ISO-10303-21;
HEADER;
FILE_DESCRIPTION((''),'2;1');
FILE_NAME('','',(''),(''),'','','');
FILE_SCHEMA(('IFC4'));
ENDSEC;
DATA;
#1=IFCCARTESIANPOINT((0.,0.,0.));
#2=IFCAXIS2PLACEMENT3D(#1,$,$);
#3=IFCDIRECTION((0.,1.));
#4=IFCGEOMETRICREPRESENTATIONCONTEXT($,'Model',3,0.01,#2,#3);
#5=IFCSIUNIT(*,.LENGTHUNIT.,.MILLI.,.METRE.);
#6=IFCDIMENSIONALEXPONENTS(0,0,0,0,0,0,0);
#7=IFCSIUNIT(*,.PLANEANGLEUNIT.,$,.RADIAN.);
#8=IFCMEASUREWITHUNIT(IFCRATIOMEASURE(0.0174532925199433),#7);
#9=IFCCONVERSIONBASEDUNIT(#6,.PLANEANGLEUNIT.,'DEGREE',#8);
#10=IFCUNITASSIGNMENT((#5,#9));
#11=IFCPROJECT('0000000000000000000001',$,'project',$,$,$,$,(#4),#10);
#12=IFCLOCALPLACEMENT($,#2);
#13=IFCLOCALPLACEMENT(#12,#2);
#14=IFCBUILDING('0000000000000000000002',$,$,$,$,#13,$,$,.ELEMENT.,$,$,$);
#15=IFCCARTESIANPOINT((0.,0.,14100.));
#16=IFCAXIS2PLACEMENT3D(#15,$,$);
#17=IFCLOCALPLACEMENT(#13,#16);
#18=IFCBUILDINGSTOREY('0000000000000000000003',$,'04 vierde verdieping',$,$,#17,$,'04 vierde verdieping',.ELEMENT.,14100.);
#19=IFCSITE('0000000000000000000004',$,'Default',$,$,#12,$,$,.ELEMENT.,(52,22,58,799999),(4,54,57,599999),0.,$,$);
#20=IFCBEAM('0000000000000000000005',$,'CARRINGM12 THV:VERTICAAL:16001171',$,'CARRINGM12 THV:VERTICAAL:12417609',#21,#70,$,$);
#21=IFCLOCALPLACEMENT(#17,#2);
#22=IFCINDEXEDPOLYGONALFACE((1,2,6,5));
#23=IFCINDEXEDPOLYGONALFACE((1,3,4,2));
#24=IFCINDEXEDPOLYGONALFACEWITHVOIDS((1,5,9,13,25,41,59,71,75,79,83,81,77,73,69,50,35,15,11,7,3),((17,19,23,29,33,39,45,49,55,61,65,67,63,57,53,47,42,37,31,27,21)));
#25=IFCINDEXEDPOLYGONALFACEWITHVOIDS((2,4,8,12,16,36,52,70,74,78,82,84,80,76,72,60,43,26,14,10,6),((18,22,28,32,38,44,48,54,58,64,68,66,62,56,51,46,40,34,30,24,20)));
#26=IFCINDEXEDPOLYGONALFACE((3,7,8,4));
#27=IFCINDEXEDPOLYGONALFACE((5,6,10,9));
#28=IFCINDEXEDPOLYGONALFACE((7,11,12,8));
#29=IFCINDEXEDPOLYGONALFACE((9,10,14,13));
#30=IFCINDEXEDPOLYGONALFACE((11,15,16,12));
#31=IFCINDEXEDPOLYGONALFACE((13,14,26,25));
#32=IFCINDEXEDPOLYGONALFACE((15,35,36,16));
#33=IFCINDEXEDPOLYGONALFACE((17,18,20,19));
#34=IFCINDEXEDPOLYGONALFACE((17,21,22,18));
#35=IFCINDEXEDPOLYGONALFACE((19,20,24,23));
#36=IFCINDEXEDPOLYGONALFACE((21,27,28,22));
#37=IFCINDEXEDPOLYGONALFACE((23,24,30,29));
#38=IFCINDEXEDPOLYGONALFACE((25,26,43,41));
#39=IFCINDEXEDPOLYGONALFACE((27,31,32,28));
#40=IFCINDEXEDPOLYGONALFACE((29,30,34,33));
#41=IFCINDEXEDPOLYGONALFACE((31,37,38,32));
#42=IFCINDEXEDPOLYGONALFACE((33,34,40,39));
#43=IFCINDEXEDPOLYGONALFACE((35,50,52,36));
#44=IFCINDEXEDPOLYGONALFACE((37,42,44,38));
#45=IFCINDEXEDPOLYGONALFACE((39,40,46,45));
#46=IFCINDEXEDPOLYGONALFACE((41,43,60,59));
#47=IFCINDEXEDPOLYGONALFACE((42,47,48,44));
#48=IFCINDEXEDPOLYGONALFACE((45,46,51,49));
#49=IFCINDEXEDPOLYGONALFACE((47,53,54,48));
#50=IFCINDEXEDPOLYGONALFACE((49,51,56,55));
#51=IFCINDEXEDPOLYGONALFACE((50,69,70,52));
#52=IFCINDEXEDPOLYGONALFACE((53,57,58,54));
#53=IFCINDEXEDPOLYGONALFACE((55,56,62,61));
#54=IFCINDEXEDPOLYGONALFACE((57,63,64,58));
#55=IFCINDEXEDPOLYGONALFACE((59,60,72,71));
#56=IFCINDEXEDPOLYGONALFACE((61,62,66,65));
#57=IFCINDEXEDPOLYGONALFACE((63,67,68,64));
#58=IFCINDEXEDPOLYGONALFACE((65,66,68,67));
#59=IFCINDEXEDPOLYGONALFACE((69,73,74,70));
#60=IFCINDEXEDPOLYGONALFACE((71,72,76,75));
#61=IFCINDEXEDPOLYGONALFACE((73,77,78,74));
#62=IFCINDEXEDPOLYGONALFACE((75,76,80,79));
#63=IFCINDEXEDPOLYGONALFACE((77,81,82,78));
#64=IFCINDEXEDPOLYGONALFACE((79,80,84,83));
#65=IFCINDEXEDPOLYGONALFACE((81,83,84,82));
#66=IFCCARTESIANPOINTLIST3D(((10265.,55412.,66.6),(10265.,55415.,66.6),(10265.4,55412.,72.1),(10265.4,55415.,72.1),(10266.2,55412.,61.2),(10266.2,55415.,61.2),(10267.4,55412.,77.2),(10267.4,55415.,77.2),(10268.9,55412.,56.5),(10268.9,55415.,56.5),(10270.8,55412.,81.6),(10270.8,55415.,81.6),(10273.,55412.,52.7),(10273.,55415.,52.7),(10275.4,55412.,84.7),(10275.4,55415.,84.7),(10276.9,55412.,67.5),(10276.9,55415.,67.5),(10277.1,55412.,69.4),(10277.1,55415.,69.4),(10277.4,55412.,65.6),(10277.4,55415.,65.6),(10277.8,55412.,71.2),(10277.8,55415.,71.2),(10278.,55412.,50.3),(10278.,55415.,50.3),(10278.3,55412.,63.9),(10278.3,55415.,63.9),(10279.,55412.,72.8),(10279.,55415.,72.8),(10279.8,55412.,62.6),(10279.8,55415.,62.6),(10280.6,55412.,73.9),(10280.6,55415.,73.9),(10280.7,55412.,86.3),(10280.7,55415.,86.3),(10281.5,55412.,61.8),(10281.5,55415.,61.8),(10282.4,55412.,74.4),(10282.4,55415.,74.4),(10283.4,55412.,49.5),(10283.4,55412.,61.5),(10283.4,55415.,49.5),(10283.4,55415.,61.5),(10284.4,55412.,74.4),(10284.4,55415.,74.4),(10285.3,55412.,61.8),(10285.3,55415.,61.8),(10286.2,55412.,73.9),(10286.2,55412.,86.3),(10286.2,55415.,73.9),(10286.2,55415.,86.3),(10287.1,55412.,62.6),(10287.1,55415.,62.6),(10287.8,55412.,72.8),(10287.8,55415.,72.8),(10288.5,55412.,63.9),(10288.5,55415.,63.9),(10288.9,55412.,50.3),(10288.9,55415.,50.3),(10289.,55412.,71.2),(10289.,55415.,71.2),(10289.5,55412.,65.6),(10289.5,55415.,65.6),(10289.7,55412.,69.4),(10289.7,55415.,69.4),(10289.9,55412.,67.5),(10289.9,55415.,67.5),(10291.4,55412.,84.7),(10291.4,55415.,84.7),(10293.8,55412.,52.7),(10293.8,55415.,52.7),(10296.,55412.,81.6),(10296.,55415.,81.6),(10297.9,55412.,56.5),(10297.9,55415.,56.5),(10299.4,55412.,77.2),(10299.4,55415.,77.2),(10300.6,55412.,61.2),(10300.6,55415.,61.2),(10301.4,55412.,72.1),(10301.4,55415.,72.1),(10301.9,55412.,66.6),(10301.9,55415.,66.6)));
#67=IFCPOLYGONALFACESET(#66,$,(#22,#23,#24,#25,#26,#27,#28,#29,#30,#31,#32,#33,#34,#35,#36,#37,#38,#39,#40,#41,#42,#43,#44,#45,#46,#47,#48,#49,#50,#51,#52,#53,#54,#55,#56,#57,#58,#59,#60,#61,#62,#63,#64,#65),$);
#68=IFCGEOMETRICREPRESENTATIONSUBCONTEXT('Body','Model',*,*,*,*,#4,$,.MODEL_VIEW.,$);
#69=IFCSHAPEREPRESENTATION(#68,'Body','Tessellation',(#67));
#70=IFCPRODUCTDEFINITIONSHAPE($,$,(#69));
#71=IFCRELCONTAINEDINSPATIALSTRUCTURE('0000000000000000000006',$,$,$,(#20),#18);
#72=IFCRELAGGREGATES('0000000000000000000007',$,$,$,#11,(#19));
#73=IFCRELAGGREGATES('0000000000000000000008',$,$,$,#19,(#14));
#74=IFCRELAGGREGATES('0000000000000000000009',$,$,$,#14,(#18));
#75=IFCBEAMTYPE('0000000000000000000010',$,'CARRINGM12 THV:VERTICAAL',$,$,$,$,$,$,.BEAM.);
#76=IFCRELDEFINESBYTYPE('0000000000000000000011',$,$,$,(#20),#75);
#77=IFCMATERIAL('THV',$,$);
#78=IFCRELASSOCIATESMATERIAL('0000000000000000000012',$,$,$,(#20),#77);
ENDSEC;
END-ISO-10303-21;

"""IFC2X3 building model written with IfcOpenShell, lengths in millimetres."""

from ifc_helpers import new_model, entity, si_unit, converted_unit, direction, frame, origin, origin_2d_with_axis, place, context, subcontext, project, spatial, hollow_circle, extrude, material, type_object, element, save


model = new_model("IFC2X3")

# Units and contexts
model_context = context("Model", 3, precision=0.01, world=origin(), true_north=direction((0.0, 1.0)))
body_context = subcontext(model_context, "Body", "Model", "MODEL_VIEW")
ifc_project = project(units=[si_unit("LENGTHUNIT", "METRE", prefix="MILLI"), converted_unit("PLANEANGLEUNIT", "DEGREE", entity("IfcRatioMeasure", 0.0174532925199433), si_unit("PLANEANGLEUNIT", "RADIAN"), dimensions=[0, 0, 0, 0, 0, 0, 0])], contexts=[model_context])

# Site, building, storey
site_placement = place(None, origin())
site = spatial("IfcSite", under=ifc_project, at=site_placement, Name="Default", CompositionType="ELEMENT", RefLatitude=(52, 22, 58, 799999), RefLongitude=(4, 54, 57, 599999), RefElevation=0.0)
building_placement = place(site_placement, origin())
building = spatial("IfcBuilding", under=site, at=building_placement, CompositionType="ELEMENT")
storey_placement = place(building_placement, frame((0.0, 0.0, 14100.0)))
storey = spatial("IfcBuildingStorey", under=building, at=storey_placement, Name="04 vierde verdieping", LongName="04 vierde verdieping", CompositionType="ELEMENT", Elevation=14100.0)

# Beam
ifc_material_1 = material(Name="THV")
beam_type_1 = type_object("IfcBeamType", Name="CARRINGM12 THV:VERTICAAL", PredefinedType="BEAM")
beam_1_placement = place(storey_placement, origin())
element("IfcBeam", 1, at=beam_1_placement, inside=storey, type_object=beam_type_1, material=ifc_material_1, Name="CARRINGM12 THV:VERTICAAL:16001171", ObjectType="CARRINGM12 THV:VERTICAAL:12417609", context=body_context, shape_type="SweptSolid", body=[
    extrude(hollow_circle(Radius=18.5, WallThickness=12.0, at=origin_2d_with_axis()), frame((10283.4, 55412.0, 68.0), z_axis=(0.0, 1.0, 0.0), x_axis=(0.0, 0.0, -1.0)), (0.0, 0.0, 1.0), 3.0),
])

save(model, "model.ifc")
